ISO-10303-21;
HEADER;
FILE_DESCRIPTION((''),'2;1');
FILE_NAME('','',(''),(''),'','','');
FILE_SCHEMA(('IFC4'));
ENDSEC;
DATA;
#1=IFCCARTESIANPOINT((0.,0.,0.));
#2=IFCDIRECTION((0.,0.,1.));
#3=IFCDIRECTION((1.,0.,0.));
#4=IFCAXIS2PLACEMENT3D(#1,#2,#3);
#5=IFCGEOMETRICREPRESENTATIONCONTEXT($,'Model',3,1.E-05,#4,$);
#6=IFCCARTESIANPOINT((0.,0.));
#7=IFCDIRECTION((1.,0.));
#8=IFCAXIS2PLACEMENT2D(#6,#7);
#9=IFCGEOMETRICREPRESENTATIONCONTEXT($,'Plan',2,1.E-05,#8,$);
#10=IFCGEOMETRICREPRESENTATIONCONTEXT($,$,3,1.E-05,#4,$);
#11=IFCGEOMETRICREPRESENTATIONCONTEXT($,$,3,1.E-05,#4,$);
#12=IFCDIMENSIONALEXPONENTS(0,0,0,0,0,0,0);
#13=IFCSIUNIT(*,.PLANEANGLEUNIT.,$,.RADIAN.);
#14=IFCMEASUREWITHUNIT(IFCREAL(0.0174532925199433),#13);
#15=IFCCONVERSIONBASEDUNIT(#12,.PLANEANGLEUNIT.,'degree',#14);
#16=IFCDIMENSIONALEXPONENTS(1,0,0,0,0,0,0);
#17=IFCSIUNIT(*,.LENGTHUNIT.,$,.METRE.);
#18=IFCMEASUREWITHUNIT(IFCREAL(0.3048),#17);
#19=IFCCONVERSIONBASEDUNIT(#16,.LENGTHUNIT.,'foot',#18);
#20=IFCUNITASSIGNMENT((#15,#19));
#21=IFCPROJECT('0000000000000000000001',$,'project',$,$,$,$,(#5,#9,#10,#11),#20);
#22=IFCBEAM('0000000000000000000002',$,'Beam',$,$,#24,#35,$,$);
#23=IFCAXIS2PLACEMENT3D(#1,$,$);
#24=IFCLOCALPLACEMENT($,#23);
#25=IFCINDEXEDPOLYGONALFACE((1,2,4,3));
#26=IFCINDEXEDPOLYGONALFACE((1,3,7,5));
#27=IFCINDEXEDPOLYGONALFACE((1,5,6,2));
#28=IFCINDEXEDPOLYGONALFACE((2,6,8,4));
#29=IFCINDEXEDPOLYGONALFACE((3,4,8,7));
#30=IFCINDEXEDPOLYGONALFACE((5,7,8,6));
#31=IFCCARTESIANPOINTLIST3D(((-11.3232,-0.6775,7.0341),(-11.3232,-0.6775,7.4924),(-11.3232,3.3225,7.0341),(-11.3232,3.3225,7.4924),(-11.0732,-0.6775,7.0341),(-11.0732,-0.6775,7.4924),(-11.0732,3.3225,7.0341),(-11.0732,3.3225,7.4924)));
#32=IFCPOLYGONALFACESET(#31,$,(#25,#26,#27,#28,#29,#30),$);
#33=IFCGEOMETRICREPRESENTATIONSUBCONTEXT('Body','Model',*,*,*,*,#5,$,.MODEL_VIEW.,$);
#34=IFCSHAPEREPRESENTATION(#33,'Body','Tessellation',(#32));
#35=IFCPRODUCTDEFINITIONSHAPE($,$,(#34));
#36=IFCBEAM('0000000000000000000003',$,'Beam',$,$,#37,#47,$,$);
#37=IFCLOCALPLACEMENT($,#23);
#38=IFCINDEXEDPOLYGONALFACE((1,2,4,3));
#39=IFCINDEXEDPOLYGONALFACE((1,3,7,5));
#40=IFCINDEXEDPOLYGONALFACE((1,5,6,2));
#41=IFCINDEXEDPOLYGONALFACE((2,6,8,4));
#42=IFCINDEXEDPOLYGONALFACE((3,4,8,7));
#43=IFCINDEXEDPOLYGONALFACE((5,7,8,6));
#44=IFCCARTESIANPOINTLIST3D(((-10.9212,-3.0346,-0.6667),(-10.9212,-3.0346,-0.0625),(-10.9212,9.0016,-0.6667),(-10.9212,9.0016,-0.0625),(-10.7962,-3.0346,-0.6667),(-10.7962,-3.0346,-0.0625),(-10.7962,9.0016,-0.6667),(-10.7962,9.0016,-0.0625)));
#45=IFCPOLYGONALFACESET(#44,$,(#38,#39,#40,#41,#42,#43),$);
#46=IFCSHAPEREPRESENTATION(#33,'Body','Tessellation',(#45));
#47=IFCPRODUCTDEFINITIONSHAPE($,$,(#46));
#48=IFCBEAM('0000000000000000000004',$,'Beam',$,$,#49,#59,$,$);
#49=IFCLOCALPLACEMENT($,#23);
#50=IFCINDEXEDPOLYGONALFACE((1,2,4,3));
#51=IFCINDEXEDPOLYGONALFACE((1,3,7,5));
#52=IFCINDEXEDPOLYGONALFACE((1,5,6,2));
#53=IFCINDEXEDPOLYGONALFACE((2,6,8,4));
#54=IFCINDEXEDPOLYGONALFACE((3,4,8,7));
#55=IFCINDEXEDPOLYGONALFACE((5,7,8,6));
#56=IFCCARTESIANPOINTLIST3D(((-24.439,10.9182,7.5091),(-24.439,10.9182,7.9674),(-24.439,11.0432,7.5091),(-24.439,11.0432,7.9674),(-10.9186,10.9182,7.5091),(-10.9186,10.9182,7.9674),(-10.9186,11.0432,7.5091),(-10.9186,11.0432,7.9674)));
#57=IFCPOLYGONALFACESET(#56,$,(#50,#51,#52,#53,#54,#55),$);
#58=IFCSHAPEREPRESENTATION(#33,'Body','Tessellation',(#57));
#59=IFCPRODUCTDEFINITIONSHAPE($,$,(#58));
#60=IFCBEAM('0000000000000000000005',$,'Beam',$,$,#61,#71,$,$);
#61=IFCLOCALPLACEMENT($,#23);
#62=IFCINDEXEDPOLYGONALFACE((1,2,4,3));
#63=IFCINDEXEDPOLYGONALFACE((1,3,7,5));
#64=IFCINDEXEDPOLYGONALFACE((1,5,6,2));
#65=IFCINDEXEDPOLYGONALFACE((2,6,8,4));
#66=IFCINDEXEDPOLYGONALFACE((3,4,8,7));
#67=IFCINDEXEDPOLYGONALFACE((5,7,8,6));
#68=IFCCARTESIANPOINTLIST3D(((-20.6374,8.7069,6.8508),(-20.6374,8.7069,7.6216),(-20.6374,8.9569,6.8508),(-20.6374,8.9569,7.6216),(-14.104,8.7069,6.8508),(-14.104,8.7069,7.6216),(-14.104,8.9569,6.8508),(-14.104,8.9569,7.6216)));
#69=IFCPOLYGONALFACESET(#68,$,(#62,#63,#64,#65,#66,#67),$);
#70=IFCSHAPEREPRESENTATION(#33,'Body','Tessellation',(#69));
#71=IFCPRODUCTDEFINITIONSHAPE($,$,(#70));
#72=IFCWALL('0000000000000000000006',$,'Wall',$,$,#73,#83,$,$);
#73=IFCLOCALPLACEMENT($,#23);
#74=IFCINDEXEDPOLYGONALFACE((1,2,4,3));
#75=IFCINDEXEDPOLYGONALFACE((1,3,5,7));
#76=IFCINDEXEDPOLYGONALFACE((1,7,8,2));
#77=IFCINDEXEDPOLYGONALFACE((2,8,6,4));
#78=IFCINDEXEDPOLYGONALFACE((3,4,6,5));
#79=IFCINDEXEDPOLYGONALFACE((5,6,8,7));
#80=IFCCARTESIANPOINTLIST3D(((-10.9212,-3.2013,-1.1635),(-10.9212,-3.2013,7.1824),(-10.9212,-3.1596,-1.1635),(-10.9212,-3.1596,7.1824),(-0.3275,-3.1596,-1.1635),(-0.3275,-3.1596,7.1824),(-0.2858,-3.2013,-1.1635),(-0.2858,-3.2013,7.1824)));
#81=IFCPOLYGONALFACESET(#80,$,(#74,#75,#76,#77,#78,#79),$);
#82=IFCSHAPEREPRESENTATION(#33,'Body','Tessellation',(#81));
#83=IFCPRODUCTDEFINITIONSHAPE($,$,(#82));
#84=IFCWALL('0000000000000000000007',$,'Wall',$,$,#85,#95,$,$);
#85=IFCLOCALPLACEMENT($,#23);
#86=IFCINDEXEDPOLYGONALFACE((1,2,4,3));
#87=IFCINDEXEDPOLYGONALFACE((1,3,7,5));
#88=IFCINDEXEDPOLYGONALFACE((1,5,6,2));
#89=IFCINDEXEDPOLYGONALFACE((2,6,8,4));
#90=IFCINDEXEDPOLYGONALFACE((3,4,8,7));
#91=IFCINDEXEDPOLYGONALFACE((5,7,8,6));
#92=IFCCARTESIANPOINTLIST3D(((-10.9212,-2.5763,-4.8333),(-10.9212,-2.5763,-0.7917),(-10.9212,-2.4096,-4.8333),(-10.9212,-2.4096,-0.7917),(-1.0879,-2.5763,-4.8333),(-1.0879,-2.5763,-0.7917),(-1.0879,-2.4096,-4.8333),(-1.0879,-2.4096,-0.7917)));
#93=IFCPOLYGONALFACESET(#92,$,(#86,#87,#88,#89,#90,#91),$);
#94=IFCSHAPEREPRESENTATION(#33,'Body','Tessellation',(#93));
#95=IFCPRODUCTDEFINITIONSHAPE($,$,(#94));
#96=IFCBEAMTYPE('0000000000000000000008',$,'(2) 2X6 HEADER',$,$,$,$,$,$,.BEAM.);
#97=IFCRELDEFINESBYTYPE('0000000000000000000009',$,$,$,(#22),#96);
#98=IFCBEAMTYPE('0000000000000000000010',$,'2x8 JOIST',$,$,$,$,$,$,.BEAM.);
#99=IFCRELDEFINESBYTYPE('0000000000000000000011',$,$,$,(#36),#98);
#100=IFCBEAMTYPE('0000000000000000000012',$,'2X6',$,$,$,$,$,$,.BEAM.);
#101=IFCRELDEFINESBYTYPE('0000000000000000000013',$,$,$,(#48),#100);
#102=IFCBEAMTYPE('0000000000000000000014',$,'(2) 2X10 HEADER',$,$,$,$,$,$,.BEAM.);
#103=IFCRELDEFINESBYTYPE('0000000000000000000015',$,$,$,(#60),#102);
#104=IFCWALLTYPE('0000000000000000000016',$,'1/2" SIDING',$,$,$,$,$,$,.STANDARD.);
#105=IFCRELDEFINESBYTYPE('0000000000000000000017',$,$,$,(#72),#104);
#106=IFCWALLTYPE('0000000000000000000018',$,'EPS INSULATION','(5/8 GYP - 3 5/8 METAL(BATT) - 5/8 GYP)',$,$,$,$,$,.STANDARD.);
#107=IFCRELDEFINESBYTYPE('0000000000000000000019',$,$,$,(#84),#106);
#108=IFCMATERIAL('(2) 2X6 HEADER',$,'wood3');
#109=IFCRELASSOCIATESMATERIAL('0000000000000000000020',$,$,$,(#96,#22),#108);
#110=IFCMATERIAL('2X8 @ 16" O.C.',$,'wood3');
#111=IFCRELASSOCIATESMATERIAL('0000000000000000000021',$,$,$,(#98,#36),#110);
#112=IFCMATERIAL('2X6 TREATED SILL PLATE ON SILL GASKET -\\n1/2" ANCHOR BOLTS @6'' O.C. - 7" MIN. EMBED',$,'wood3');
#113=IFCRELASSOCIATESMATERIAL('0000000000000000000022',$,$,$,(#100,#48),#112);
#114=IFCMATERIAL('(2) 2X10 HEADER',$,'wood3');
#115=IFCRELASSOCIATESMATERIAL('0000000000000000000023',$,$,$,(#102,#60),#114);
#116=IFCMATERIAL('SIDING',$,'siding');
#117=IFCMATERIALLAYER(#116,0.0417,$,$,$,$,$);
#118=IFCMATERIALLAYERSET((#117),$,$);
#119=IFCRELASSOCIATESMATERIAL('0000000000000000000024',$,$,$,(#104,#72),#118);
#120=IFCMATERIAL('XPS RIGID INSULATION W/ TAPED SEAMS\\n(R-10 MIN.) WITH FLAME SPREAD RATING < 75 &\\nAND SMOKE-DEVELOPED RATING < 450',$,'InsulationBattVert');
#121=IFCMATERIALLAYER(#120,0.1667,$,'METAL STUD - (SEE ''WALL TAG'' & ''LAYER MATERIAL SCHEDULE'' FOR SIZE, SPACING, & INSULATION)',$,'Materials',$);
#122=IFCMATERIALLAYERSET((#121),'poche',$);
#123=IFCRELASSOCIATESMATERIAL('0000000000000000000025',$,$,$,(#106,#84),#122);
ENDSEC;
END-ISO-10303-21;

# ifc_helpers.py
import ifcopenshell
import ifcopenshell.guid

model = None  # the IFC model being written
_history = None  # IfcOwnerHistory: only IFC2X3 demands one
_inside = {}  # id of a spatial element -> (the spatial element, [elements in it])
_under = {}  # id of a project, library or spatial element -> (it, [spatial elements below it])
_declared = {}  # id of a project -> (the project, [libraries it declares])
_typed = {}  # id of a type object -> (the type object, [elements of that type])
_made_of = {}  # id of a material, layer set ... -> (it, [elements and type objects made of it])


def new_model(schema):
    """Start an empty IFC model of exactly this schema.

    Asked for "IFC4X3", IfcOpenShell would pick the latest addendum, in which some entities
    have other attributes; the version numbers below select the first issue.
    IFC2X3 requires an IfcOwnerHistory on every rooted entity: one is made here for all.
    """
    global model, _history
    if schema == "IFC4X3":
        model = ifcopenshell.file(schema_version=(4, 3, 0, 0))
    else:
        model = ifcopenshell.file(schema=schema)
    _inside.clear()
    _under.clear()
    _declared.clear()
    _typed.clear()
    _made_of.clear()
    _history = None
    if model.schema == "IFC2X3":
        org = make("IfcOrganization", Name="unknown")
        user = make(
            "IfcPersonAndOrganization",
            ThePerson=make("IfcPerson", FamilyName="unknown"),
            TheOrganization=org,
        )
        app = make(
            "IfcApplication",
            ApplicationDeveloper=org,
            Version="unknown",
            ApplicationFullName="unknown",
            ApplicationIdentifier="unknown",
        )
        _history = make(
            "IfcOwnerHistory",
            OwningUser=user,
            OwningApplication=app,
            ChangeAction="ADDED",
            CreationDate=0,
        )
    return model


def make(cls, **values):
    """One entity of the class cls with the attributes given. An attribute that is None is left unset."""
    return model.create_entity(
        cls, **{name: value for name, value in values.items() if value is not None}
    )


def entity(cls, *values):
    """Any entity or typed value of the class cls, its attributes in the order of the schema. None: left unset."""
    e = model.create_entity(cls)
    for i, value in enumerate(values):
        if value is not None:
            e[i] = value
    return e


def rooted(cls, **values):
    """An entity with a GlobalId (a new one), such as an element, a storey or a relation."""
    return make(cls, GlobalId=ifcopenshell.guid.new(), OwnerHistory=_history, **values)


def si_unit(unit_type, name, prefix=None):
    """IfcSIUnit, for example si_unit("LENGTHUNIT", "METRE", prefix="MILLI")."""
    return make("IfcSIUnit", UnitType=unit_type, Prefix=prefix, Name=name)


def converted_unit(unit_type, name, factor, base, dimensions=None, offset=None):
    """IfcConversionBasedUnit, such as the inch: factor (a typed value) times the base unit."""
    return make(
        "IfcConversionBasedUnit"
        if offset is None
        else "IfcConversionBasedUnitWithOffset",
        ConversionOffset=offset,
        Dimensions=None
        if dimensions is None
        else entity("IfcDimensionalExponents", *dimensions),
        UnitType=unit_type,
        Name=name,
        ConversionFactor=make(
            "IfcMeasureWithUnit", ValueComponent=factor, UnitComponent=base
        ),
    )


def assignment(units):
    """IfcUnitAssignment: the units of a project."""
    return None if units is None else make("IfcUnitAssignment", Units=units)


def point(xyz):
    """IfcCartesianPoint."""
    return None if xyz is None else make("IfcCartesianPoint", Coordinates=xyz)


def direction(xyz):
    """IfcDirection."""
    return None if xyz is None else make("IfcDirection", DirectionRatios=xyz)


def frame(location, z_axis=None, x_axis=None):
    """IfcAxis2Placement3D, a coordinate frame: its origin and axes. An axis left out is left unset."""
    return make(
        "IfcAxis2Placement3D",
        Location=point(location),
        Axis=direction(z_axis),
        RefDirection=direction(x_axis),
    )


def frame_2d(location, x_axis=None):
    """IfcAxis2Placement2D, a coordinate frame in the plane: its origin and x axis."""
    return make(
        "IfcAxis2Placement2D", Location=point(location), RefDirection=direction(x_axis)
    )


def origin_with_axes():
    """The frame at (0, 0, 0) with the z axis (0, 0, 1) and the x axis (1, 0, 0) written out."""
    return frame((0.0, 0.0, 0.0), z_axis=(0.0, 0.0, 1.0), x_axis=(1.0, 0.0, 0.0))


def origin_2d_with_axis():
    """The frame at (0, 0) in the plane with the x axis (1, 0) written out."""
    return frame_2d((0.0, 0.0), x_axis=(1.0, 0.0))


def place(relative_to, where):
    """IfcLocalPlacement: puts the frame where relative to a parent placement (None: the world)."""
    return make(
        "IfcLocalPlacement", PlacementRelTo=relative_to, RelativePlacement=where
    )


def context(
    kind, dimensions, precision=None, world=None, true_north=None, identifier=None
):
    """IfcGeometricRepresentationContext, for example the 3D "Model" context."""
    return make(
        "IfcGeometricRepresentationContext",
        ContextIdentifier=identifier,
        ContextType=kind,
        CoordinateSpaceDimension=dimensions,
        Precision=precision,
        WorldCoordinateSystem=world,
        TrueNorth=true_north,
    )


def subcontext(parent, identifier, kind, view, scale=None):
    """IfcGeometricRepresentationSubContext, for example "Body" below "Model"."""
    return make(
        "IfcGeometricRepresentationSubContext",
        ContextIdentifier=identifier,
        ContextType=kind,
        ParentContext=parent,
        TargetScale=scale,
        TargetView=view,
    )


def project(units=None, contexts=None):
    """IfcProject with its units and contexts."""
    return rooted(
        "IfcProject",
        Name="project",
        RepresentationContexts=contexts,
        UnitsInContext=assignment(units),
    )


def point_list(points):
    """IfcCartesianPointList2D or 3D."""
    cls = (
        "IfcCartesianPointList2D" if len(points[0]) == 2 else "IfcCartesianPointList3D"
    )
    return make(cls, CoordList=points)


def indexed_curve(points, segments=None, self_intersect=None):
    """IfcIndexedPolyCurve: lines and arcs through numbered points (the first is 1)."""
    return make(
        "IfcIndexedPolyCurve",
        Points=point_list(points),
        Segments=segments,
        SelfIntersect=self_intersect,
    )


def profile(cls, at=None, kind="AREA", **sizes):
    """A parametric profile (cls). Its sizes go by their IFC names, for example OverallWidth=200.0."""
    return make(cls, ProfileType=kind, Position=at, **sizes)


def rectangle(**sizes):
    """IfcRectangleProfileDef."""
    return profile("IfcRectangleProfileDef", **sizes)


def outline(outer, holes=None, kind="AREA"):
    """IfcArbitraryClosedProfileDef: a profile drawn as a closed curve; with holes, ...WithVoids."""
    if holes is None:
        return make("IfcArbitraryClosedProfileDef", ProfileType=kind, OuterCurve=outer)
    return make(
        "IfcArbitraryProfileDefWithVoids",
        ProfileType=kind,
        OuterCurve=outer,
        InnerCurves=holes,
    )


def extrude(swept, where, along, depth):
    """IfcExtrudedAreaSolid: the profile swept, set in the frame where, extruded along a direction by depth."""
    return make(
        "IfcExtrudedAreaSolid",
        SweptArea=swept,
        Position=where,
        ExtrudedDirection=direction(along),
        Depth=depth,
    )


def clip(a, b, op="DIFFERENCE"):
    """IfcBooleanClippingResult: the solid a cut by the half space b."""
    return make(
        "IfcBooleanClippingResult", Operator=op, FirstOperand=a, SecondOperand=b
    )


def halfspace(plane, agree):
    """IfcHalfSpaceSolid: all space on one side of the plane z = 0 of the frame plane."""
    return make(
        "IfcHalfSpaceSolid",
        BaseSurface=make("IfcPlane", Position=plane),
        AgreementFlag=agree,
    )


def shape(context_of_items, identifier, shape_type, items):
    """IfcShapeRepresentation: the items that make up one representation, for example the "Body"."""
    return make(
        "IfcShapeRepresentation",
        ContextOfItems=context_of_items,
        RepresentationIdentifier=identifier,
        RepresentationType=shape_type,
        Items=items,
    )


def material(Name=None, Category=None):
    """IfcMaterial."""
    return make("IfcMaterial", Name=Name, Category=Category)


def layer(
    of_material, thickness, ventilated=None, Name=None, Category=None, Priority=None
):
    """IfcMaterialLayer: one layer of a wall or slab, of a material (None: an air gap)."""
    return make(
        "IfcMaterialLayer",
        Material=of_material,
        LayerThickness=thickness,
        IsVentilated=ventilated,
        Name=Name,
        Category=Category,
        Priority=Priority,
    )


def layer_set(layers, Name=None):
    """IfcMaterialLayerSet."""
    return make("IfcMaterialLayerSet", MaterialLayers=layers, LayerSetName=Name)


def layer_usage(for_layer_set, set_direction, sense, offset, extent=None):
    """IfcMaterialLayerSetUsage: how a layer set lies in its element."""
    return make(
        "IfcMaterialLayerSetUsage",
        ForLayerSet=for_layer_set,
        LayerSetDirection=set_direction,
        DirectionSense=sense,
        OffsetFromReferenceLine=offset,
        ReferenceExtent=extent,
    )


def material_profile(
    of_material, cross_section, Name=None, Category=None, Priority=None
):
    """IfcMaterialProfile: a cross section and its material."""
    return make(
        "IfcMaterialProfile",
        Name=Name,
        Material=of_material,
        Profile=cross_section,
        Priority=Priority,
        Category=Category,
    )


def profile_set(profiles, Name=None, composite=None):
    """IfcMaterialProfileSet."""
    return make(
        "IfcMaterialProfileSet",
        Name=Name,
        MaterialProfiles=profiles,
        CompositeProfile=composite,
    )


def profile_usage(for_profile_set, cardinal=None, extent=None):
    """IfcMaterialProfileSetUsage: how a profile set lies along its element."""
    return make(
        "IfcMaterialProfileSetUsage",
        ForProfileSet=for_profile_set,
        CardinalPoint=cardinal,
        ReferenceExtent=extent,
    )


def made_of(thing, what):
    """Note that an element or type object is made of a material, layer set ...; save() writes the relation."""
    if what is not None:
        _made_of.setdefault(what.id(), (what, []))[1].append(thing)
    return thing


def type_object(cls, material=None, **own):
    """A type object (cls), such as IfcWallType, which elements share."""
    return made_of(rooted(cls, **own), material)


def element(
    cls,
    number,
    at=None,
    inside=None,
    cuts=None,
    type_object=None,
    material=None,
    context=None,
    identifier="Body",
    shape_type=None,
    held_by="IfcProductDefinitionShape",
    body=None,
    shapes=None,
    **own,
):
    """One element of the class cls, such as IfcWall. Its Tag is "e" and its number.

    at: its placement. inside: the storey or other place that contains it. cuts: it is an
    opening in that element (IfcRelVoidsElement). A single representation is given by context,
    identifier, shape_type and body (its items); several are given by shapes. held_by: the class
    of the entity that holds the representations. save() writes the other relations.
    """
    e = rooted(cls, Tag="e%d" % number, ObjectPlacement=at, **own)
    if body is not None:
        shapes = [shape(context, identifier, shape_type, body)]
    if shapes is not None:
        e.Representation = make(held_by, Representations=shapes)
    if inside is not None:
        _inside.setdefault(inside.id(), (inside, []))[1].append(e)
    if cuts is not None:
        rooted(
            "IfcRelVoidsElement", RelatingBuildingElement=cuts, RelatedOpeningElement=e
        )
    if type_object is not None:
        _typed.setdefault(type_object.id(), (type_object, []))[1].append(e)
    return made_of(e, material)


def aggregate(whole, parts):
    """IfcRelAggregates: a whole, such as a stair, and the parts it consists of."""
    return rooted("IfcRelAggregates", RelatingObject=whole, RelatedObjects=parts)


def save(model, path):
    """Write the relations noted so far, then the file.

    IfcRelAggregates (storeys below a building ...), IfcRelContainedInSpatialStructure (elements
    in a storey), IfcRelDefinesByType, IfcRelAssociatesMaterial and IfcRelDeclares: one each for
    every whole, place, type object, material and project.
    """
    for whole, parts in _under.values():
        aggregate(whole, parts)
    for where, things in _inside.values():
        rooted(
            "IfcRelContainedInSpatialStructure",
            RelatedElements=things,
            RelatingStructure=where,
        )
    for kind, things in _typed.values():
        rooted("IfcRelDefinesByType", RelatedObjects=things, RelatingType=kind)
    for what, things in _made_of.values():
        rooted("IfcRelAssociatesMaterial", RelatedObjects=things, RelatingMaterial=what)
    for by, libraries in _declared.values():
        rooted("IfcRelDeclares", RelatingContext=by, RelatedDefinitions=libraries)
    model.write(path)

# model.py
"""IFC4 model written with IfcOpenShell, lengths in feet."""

from ifc_helpers import new_model, entity, si_unit, converted_unit, frame, origin_with_axes, origin_2d_with_axis, place, context, subcontext, project, indexed_curve, rectangle, outline, extrude, clip, halfspace, material, layer, layer_set, layer_usage, material_profile, profile_set, profile_usage, type_object, element, save


model = new_model("IFC4")

# Units and contexts
model_context = context("Model", 3, precision=1e-05, world=origin_with_axes())
plan_context = context("Plan", 2, precision=1e-05, world=origin_2d_with_axis())
context_of_model_1 = context(None, 3, precision=1e-05, world=origin_with_axes())
context_of_model_2 = context(None, 3, precision=1e-05, world=origin_with_axes())
body_context = subcontext(model_context, "Body", "Model", "MODEL_VIEW")
ifc_project = project(units=[converted_unit("PLANEANGLEUNIT", "degree", entity("IfcReal", 0.0174532925199433), si_unit("PLANEANGLEUNIT", "RADIAN"), dimensions=[0, 0, 0, 0, 0, 0, 0]), converted_unit("LENGTHUNIT", "foot", entity("IfcReal", 0.3048), si_unit("LENGTHUNIT", "METRE"), dimensions=[1, 0, 0, 0, 0, 0, 0])], contexts=[model_context, plan_context, context_of_model_1, context_of_model_2])

# Beams
ifc_material_1 = material(Name="2X6 TREATED SILL PLATE ON SILL GASKET -\\n1/2\" ANCHOR BOLTS @6' O.C. - 7\" MIN. EMBED", Category="wood3")
ifc_material_2 = material(Name="(2) 2X6 HEADER", Category="wood3")
ifc_material_profile_1 = material_profile(ifc_material_2, rectangle(XDim=0.25, YDim=0.4583))
ifc_profile_set_1 = profile_set([ifc_material_profile_1])
ifc_profile_usage_1 = profile_usage(ifc_profile_set_1, cardinal=5)
beam_type_1 = type_object("IfcBeamType", Name="(2) 2X6 HEADER", PredefinedType="BEAM", material=ifc_profile_set_1)
beam_1_placement = place(None, frame((-11.1982, 3.3225, 7.2633), z_axis=(0.0, -1.0, 0.0), x_axis=(1.0, 0.0, 0.0)))
element("IfcBeam", 1, at=beam_1_placement, type_object=beam_type_1, material=ifc_profile_usage_1, Name="Beam", context=body_context, shape_type="SweptSolid", body=[
    extrude(rectangle(XDim=0.25, YDim=0.4583), origin_with_axes(), (0.0, 0.0, 1.0), 4.0),
])
ifc_material_3 = material(Name="2X8 @ 16\" O.C.", Category="wood3")
ifc_material_profile_2 = material_profile(ifc_material_3, rectangle(XDim=0.125, YDim=0.6042))
ifc_profile_set_2 = profile_set([ifc_material_profile_2])
ifc_profile_usage_2 = profile_usage(ifc_profile_set_2, cardinal=5)
beam_type_2 = type_object("IfcBeamType", Name="2x8 JOIST", PredefinedType="BEAM", material=ifc_profile_set_2)
beam_2_placement = place(None, frame((-10.8587, -3.0346, -0.3646), z_axis=(0.0, 1.0, 0.0), x_axis=(-1.0, 0.0, 0.0)))
element("IfcBeam", 2, at=beam_2_placement, type_object=beam_type_2, material=ifc_profile_usage_2, Name="Beam", context=body_context, shape_type="SweptSolid", body=[
    extrude(rectangle(XDim=0.125, YDim=0.6042), origin_with_axes(), (0.0, 0.0, 1.0), 12.0362),
])
ifc_material_profile_3 = material_profile(ifc_material_1, rectangle(XDim=0.125, YDim=0.4583))
ifc_profile_set_3 = profile_set([ifc_material_profile_3])
ifc_profile_usage_3 = profile_usage(ifc_profile_set_3, cardinal=5)
beam_type_3 = type_object("IfcBeamType", Name="2X6", PredefinedType="BEAM", material=ifc_profile_set_3)
beam_3_placement = place(None, frame((-10.9186, 10.9807, 7.7383), z_axis=(-1.0, 0.0, 0.0), x_axis=(0.0, -1.0, 0.0)))
element("IfcBeam", 3, at=beam_3_placement, type_object=beam_type_3, material=ifc_profile_usage_3, Name="Beam", context=body_context, shape_type="SweptSolid", body=[
    extrude(rectangle(XDim=0.125, YDim=0.4583), origin_with_axes(), (0.0, 0.0, 1.0), 13.5204),
])
ifc_material_4 = material(Name="(2) 2X10 HEADER", Category="wood3")
ifc_material_profile_4 = material_profile(ifc_material_4, rectangle(XDim=0.25, YDim=0.7708))
ifc_profile_set_4 = profile_set([ifc_material_profile_4])
ifc_profile_usage_4 = profile_usage(ifc_profile_set_4, cardinal=5)
beam_type_4 = type_object("IfcBeamType", Name="(2) 2X10 HEADER", PredefinedType="BEAM", material=ifc_profile_set_4)
beam_4_placement = place(None, frame((-20.6374, 8.8319, 7.2362), z_axis=(1.0, 0.0, 0.0), x_axis=(0.0, 1.0, 0.0)))
element("IfcBeam", 4, at=beam_4_placement, type_object=beam_type_4, material=ifc_profile_usage_4, Name="Beam", context=body_context, shape_type="SweptSolid", body=[
    extrude(rectangle(XDim=0.25, YDim=0.7708), origin_with_axes(), (0.0, 0.0, 1.0), 6.5334),
])

# Walls
ifc_material_5 = material(Name="SIDING", Category="siding")
ifc_layer_1 = layer(ifc_material_5, 0.0417)
ifc_layer_set_1 = layer_set([ifc_layer_1])
ifc_layer_usage_1 = layer_usage(ifc_layer_set_1, "AXIS2", "POSITIVE", 0.0)
wall_type_1 = type_object("IfcWallType", Name="1/2\" SIDING", PredefinedType="STANDARD", material=ifc_layer_set_1)
wall_1_placement = place(None, frame((-10.9212, -3.2013, -1.1635), z_axis=(0.0, 0.0, 1.0), x_axis=(1.0, 0.0, 0.0)))
element("IfcWall", 5, at=wall_1_placement, type_object=wall_type_1, material=ifc_layer_usage_1, Name="Wall", context=body_context, shape_type="Clipping", body=[
    clip(extrude(outline(indexed_curve([(0.0, 0.0), (0.0, 0.0417), (10.6354, 0.0417), (10.6354, 0.0), (0.0, 0.0)], self_intersect=False)), origin_with_axes(), (0.0, 0.0, 1.0), 8.3459), halfspace(frame((10.6354, 0.0, 1.1635), z_axis=(0.707106, 0.707107, 0.0), x_axis=(0.707107, -0.707106, 0.0)), False)),
])
ifc_material_6 = material(Name="XPS RIGID INSULATION W/ TAPED SEAMS\\n(R-10 MIN.) WITH FLAME SPREAD RATING < 75 &\\nAND SMOKE-DEVELOPED RATING < 450", Category="InsulationBattVert")
ifc_layer_2 = layer(ifc_material_6, 0.1667, Name="METAL STUD - (SEE 'WALL TAG' & 'LAYER MATERIAL SCHEDULE' FOR SIZE, SPACING, & INSULATION)", Category="Materials")
ifc_layer_set_2 = layer_set([ifc_layer_2], Name="poche")
ifc_layer_usage_2 = layer_usage(ifc_layer_set_2, "AXIS2", "POSITIVE", 0.0)
wall_type_2 = type_object("IfcWallType", Name="EPS INSULATION", Description="(5/8 GYP - 3 5/8 METAL(BATT) - 5/8 GYP)", PredefinedType="STANDARD", material=ifc_layer_set_2)
wall_2_placement = place(None, frame((-10.9212, -2.5763, -4.8333), z_axis=(0.0, 0.0, 1.0), x_axis=(1.0, 0.0, 0.0)))
element("IfcWall", 6, at=wall_2_placement, type_object=wall_type_2, material=ifc_layer_usage_2, Name="Wall", context=body_context, shape_type="SweptSolid", body=[
    extrude(outline(indexed_curve([(0.0, 0.0), (0.0, 0.1667), (9.8333, 0.1667), (9.8333, 0.0), (0.0, 0.0)], self_intersect=False)), origin_with_axes(), (0.0, 0.0, 1.0), 4.0417),
])

save(model, "model.ifc")
